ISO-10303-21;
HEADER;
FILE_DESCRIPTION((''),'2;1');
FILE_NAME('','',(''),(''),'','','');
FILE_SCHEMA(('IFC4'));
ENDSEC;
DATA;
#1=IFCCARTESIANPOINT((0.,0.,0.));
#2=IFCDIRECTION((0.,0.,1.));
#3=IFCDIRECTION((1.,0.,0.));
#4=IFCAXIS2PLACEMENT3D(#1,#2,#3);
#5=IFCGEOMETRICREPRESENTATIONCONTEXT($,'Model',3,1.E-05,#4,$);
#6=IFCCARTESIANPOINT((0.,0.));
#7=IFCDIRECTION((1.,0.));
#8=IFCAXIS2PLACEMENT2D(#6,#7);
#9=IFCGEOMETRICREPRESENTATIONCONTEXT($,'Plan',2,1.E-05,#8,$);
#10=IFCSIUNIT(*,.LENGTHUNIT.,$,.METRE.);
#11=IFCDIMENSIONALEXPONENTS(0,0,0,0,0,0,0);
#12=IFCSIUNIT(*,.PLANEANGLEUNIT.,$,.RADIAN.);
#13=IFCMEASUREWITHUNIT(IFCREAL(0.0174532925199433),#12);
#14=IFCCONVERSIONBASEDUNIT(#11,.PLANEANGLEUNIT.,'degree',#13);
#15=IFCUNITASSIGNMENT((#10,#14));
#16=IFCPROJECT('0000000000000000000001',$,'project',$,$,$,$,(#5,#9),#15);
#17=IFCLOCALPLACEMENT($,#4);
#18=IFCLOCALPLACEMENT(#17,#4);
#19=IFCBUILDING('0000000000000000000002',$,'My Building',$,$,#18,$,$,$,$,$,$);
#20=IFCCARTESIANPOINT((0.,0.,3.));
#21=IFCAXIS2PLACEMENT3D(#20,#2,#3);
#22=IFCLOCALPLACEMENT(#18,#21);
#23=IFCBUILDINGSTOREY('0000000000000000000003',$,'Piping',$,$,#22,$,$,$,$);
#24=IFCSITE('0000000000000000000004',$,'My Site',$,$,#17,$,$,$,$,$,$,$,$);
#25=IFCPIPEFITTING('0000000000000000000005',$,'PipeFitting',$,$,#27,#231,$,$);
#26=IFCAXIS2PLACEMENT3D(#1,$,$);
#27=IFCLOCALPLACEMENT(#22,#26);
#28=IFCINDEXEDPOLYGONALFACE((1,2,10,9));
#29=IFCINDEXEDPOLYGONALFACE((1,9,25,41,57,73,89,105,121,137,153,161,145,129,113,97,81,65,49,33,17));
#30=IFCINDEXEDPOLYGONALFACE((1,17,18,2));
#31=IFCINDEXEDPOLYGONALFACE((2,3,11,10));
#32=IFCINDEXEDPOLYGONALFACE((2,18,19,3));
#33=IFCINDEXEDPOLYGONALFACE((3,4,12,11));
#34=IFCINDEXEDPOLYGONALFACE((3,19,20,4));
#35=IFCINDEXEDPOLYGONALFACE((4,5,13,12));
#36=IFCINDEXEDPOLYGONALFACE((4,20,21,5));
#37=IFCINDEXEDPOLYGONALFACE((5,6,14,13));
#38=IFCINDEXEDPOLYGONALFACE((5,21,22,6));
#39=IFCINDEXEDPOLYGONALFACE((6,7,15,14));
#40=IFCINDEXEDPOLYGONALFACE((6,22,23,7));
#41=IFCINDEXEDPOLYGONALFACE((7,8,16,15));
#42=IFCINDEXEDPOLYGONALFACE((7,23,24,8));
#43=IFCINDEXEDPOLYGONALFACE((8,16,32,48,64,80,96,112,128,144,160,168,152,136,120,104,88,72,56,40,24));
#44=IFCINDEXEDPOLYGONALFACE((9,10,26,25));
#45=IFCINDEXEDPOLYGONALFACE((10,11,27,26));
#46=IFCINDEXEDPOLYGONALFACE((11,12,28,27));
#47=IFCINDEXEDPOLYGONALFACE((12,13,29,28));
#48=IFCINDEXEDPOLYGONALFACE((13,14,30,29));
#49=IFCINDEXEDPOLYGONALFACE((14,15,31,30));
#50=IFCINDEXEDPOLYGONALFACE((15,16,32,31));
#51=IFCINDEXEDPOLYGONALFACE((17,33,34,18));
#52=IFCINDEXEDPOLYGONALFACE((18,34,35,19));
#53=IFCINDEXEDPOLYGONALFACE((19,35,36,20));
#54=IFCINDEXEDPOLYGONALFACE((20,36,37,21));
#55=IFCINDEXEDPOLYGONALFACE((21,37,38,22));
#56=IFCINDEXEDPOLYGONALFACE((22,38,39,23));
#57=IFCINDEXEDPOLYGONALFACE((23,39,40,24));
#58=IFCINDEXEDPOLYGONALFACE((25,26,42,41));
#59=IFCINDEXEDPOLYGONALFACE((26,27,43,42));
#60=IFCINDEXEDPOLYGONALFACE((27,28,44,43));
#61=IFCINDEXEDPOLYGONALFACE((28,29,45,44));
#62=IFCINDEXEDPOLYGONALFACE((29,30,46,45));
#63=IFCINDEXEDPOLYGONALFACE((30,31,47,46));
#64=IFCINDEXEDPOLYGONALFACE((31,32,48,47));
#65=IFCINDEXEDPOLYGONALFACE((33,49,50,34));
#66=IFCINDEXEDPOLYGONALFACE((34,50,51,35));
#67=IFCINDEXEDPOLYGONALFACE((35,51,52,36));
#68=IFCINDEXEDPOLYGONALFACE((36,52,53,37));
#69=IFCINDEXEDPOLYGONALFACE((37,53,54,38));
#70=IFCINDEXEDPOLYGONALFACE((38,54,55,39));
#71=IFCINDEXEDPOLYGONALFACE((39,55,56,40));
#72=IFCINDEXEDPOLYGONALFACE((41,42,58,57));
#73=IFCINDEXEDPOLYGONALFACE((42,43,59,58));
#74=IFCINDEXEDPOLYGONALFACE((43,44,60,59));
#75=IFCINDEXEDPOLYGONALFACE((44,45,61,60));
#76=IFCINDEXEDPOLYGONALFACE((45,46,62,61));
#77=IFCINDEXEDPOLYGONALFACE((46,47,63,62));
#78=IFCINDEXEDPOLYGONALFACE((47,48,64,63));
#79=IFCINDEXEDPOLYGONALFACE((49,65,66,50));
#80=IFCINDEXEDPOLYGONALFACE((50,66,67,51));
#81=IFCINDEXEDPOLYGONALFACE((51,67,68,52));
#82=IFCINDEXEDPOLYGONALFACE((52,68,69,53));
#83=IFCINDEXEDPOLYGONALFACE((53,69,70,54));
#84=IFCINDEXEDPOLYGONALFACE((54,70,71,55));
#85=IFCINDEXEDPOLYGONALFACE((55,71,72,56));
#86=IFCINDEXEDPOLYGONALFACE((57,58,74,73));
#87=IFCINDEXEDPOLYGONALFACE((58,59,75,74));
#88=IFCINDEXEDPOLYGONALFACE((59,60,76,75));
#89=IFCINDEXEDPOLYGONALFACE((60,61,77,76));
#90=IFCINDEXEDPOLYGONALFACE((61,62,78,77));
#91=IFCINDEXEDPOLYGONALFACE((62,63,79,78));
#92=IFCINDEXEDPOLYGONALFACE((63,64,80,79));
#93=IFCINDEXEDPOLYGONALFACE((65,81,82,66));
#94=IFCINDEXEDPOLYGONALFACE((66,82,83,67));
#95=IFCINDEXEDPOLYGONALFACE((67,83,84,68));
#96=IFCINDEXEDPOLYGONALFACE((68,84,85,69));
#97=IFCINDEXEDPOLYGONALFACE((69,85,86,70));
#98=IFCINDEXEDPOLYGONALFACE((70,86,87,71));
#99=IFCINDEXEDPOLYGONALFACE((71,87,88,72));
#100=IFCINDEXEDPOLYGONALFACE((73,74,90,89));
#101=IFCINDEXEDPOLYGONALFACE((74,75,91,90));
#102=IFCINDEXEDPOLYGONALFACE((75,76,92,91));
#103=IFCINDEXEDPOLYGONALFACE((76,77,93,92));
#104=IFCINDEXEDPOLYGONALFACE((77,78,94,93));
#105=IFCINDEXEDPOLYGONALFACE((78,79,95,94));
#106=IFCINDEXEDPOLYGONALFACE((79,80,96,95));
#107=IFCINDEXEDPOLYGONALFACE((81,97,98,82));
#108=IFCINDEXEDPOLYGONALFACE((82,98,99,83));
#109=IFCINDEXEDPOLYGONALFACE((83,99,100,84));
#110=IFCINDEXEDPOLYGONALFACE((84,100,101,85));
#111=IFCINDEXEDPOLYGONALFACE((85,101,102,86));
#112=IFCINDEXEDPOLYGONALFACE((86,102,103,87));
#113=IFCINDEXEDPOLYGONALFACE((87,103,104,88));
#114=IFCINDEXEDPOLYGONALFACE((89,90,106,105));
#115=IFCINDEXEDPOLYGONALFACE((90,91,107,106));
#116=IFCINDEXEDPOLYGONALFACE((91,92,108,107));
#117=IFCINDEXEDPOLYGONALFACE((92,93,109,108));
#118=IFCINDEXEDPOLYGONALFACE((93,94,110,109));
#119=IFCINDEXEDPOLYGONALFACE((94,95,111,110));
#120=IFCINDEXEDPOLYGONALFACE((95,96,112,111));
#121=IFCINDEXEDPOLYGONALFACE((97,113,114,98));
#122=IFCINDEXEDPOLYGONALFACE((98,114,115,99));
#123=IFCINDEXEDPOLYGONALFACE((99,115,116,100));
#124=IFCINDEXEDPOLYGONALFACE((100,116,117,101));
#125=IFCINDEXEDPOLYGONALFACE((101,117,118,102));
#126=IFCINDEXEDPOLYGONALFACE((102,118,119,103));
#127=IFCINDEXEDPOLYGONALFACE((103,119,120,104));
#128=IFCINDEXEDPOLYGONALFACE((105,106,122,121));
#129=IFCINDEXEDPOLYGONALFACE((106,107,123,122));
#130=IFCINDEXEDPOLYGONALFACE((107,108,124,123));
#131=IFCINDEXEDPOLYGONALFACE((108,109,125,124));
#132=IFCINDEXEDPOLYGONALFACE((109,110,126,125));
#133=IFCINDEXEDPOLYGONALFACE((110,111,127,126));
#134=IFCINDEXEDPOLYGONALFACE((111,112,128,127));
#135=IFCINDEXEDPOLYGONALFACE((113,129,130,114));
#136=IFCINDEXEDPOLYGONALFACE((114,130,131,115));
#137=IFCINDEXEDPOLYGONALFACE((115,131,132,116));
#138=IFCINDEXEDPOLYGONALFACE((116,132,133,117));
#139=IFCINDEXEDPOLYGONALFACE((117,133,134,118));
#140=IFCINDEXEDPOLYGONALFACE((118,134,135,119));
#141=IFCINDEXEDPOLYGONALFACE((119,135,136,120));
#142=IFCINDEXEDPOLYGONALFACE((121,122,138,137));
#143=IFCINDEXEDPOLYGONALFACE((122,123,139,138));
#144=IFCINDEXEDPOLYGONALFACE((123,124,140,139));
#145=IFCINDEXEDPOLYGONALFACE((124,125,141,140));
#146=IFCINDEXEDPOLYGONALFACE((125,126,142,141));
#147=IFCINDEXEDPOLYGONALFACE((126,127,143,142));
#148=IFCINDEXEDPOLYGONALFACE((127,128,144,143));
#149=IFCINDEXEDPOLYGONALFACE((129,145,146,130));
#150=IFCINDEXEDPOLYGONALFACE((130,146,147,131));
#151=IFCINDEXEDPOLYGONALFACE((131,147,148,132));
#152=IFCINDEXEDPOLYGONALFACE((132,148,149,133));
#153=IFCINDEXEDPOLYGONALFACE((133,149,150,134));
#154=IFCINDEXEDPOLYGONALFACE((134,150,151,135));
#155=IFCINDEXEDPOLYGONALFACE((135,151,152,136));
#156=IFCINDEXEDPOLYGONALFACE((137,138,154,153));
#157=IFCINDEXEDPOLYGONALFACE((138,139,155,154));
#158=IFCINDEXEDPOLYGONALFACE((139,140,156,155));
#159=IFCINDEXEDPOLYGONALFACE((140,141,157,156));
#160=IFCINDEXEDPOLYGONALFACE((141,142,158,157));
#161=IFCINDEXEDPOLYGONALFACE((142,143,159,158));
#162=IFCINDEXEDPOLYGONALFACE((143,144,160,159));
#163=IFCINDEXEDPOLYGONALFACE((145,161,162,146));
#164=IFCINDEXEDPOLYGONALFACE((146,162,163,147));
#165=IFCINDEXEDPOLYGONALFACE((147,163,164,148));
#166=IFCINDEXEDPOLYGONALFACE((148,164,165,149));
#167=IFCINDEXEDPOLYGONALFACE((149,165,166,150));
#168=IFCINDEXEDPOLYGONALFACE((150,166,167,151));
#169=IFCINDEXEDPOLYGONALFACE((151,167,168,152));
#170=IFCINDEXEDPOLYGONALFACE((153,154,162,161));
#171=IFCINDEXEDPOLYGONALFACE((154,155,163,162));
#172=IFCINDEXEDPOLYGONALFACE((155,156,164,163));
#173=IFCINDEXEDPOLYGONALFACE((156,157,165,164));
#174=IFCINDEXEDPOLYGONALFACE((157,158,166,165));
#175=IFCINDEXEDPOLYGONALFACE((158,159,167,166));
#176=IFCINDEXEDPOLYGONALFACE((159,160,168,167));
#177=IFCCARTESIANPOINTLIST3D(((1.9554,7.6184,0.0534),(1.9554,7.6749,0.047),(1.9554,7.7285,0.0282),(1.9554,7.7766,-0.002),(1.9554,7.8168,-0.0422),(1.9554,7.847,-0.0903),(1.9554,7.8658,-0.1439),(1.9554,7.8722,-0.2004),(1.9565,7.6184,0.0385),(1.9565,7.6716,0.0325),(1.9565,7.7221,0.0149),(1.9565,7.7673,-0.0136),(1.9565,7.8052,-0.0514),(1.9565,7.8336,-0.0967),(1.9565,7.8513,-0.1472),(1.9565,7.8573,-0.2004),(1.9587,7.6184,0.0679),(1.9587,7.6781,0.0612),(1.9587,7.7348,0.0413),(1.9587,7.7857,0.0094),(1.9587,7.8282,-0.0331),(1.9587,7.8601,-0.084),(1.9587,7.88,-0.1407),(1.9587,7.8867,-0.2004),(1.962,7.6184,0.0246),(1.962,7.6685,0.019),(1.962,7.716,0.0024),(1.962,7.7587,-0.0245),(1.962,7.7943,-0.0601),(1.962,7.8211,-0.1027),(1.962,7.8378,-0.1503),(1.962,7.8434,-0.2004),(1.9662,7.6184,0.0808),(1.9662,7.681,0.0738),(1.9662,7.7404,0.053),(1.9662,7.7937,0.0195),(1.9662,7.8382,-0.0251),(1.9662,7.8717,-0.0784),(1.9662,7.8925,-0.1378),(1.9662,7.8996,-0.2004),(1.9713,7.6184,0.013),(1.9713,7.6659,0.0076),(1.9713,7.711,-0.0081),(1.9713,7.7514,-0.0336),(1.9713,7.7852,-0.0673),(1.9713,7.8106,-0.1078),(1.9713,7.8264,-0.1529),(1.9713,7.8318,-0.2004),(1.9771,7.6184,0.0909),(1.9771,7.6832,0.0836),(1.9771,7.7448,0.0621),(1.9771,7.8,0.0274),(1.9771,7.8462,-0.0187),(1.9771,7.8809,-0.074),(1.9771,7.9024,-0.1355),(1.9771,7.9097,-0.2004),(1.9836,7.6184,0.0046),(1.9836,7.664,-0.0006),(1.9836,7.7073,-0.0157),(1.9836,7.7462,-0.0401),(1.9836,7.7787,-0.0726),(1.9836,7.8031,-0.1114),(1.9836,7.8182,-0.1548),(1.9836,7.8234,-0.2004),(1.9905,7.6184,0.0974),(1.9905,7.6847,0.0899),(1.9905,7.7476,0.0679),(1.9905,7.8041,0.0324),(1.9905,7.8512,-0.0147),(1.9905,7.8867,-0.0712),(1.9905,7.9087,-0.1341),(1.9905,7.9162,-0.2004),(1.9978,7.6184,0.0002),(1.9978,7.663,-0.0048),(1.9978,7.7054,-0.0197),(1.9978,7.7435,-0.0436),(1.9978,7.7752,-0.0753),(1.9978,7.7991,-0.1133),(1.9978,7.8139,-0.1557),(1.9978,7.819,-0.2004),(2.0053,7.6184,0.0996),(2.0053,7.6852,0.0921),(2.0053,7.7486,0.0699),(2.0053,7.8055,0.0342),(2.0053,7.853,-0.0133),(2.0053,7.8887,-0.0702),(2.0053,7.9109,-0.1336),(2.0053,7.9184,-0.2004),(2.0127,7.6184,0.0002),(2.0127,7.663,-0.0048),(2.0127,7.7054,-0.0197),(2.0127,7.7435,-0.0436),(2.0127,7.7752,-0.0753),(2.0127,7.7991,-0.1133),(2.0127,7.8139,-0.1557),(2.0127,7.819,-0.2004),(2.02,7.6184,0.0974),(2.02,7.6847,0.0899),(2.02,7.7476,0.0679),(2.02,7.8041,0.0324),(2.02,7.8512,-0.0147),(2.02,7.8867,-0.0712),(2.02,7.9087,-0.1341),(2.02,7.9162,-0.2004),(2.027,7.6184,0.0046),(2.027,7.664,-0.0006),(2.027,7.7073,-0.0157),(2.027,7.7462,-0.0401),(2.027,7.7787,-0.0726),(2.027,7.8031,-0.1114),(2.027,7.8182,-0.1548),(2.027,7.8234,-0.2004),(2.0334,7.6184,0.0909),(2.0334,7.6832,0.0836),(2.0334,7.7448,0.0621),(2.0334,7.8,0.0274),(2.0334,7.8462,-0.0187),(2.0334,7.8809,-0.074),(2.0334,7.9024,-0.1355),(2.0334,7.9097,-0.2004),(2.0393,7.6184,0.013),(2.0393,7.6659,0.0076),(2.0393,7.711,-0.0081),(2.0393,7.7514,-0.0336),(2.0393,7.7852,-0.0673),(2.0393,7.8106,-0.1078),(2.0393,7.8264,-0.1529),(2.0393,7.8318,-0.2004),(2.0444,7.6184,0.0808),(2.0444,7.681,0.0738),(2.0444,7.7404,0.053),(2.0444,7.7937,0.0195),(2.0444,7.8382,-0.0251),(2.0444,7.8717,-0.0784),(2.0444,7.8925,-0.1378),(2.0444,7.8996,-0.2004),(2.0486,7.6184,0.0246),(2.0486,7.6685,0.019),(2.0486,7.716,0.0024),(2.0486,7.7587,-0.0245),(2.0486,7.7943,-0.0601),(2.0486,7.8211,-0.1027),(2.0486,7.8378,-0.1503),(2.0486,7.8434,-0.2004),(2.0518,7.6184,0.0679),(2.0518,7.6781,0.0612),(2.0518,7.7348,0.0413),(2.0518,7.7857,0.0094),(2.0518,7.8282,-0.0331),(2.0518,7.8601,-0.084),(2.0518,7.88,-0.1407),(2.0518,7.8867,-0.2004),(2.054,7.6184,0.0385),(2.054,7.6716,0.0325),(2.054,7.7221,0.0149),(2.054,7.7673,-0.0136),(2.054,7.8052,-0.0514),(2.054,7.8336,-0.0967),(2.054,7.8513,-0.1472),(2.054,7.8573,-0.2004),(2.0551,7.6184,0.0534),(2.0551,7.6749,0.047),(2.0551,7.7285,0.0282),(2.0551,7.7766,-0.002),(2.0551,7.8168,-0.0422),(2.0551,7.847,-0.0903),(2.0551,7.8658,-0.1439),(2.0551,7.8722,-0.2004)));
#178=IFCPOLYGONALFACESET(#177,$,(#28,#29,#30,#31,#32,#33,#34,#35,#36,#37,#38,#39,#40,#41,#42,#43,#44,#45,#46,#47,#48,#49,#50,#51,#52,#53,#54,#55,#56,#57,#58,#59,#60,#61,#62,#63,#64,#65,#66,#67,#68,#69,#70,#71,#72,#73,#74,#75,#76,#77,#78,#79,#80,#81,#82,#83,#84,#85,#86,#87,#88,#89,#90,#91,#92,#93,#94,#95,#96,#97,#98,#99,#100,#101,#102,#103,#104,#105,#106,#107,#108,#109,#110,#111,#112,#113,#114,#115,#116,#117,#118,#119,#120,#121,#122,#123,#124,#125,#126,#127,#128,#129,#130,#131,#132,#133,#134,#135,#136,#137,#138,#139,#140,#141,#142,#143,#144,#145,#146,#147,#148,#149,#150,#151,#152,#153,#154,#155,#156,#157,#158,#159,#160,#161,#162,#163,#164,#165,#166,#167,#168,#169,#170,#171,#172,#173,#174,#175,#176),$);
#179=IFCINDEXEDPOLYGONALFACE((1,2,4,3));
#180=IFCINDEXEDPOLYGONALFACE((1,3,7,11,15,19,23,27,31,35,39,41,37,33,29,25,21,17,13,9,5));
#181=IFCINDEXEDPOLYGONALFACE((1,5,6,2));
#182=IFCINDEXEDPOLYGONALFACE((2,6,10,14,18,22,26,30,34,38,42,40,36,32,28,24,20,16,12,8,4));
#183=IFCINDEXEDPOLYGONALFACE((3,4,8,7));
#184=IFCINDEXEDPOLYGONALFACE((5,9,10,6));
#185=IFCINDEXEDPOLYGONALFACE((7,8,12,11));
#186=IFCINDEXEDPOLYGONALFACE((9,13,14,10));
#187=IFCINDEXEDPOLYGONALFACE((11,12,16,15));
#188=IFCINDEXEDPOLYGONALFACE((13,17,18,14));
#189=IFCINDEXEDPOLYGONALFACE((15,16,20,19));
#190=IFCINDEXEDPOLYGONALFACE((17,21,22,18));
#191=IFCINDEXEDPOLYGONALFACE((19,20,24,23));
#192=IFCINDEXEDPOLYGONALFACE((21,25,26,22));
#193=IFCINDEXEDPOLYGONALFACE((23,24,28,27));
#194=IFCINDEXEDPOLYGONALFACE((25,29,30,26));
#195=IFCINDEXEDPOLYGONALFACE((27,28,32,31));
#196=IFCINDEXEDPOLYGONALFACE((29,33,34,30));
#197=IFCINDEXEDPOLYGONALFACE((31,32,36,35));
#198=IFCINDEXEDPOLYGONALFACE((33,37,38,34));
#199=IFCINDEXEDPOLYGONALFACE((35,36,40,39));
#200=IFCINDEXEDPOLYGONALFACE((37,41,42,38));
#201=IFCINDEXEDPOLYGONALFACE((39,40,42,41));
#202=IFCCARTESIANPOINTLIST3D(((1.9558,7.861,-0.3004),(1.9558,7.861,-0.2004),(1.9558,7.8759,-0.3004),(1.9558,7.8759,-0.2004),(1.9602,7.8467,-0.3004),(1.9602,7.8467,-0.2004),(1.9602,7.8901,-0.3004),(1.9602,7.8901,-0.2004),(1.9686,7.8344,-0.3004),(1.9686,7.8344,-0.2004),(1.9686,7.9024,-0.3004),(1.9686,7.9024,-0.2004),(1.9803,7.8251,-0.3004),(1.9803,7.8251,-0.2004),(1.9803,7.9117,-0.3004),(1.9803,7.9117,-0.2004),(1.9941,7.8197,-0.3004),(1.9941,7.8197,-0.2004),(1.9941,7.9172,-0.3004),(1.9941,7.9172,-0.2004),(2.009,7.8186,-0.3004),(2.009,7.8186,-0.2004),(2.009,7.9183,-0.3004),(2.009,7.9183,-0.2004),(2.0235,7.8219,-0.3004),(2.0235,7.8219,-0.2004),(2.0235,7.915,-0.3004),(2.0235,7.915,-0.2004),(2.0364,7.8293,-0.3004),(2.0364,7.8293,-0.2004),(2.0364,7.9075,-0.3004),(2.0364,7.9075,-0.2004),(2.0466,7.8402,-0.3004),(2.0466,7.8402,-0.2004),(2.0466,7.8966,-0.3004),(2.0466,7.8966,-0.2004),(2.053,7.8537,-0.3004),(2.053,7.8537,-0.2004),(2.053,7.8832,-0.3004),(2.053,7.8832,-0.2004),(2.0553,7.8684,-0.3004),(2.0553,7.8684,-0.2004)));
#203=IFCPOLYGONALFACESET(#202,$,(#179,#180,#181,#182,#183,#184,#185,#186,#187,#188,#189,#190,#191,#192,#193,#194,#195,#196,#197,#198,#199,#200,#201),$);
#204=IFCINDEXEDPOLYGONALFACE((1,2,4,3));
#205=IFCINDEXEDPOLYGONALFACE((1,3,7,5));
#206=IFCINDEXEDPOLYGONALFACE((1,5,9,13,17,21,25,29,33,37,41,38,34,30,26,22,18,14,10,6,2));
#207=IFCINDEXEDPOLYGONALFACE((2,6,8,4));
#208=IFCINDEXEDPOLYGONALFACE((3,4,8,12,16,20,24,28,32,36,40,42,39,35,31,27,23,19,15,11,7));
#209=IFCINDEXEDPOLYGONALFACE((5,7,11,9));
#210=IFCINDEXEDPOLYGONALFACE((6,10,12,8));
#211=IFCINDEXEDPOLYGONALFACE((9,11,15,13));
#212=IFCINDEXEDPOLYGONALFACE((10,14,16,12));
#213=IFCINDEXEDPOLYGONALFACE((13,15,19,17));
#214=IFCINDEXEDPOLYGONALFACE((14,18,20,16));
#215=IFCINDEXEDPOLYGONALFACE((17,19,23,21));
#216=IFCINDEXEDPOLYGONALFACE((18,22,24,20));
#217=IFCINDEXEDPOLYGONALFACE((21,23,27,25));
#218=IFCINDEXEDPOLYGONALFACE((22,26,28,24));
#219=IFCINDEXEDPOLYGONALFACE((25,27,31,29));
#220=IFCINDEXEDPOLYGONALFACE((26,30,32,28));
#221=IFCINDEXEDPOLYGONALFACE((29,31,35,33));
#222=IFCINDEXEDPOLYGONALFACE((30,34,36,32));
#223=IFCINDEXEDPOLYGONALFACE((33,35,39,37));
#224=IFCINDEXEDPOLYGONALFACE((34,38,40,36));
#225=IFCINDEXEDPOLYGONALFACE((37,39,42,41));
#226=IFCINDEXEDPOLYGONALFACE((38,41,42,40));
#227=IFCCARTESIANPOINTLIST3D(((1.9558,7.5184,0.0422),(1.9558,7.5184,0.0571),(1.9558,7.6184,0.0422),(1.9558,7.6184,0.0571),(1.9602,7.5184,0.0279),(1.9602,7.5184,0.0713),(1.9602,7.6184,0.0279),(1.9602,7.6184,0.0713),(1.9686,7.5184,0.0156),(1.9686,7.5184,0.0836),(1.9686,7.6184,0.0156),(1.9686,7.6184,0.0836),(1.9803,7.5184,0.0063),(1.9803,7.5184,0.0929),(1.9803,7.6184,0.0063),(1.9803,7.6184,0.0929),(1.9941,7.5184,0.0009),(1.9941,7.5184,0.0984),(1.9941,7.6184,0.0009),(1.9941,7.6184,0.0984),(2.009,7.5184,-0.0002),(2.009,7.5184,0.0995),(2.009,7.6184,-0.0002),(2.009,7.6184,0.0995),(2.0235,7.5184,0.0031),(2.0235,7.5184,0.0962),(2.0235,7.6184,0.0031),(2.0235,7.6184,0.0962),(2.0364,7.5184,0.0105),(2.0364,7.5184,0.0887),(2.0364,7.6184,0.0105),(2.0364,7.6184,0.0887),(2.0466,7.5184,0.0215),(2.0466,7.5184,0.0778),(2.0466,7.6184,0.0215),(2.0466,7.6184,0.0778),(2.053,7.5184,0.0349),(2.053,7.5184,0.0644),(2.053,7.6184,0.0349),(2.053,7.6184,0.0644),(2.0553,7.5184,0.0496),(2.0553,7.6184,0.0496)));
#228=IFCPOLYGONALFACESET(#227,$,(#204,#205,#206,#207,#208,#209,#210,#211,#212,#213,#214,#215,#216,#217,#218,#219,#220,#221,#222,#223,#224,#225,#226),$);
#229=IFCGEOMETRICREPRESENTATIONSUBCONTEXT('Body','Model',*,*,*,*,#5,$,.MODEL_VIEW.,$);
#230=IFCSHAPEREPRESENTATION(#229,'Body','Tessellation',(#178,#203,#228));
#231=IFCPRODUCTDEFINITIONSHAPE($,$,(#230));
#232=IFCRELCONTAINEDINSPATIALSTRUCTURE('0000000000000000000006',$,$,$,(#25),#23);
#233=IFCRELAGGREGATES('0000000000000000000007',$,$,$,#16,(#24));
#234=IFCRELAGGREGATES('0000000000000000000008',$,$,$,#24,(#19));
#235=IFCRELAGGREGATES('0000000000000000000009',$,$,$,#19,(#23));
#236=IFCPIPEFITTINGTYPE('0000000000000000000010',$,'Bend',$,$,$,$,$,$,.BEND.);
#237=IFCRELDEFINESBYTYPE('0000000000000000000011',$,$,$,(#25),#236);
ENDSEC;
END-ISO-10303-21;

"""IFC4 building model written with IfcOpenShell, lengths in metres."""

from ifc_helpers import new_model, entity, si_unit, converted_unit, frame, origin_with_axes, origin_2d_with_axis, place, context, subcontext, project, spatial, circle, extrude, source, transform, mapped, type_object, type_shapes, element, save


model = new_model("IFC4")

# Units and contexts
model_context = context("Model", 3, precision=1e-05, world=origin_with_axes())
plan_context = context("Plan", 2, precision=1e-05, world=origin_2d_with_axis())
body_context = subcontext(model_context, "Body", "Model", "MODEL_VIEW")
ifc_project = project(units=[si_unit("LENGTHUNIT", "METRE"), converted_unit("PLANEANGLEUNIT", "degree", entity("IfcReal", 0.0174532925199433), si_unit("PLANEANGLEUNIT", "RADIAN"), dimensions=[0, 0, 0, 0, 0, 0, 0])], contexts=[model_context, plan_context])

# Site, building, storey
site_placement = place(None, origin_with_axes())
site = spatial("IfcSite", under=ifc_project, at=site_placement, Name="My Site")
building_placement = place(site_placement, origin_with_axes())
building = spatial("IfcBuilding", under=site, at=building_placement, Name="My Building")
storey_placement = place(building_placement, frame((0.0, 0.0, 3.0), z_axis=(0.0, 0.0, 1.0), x_axis=(1.0, 0.0, 0.0)))
storey = spatial("IfcBuildingStorey", under=building, at=storey_placement, Name="Piping")

# Pipe fitting
pipe_fitting_type = type_object("IfcPipeFittingType", Name="Bend", PredefinedType="BEND")
shared_shape = source(origin_with_axes(), body_context, "Body", "SolidModel", [
    entity("IfcSweptDiskSolid", entity("IfcIndexedPolyCurve", entity("IfcCartesianPointList3D", [[0.0, 0.0, -0.1], [0.0, 0.0732, -0.2768], [0.0, 0.25, -0.35]]), [entity("IfcArcIndex", [1, 2, 3])]), 0.05),
    extrude(circle(Radius=0.05), origin_with_axes(), (0.0, 0.0, -1.0), 0.1),
    extrude(circle(Radius=0.05), frame((0.0, 0.25, -0.35), z_axis=(0.0, 1.0, 0.000007), x_axis=(1.0, 0.0, 0.0)), (0.0, 0.0, 1.0), 0.1),
])
type_shapes(pipe_fitting_type, [shared_shape])
for number, where, z_axis, x_axis, name in (
    (1, (2.0053, 7.8684, -0.3004), (0.0, 0.0, -1.0), (1.0, 0.0, 0.0), "PipeFitting"),
):
    element("IfcPipeFitting", number, at=place(storey_placement, frame(where, z_axis=z_axis, x_axis=x_axis)), inside=storey, type_object=pipe_fitting_type, Name=name, context=body_context, shape_type="MappedRepresentation", body=[
        mapped(shared_shape, transform((0.0, 0.0, 0.0), x_axis=(1.0, 0.0, 0.0), y_axis=(0.0, 1.0, 0.0), z_axis=(0.0, 0.0, 1.0), scale=1.0)),
    ])

save(model, "model.ifc")
